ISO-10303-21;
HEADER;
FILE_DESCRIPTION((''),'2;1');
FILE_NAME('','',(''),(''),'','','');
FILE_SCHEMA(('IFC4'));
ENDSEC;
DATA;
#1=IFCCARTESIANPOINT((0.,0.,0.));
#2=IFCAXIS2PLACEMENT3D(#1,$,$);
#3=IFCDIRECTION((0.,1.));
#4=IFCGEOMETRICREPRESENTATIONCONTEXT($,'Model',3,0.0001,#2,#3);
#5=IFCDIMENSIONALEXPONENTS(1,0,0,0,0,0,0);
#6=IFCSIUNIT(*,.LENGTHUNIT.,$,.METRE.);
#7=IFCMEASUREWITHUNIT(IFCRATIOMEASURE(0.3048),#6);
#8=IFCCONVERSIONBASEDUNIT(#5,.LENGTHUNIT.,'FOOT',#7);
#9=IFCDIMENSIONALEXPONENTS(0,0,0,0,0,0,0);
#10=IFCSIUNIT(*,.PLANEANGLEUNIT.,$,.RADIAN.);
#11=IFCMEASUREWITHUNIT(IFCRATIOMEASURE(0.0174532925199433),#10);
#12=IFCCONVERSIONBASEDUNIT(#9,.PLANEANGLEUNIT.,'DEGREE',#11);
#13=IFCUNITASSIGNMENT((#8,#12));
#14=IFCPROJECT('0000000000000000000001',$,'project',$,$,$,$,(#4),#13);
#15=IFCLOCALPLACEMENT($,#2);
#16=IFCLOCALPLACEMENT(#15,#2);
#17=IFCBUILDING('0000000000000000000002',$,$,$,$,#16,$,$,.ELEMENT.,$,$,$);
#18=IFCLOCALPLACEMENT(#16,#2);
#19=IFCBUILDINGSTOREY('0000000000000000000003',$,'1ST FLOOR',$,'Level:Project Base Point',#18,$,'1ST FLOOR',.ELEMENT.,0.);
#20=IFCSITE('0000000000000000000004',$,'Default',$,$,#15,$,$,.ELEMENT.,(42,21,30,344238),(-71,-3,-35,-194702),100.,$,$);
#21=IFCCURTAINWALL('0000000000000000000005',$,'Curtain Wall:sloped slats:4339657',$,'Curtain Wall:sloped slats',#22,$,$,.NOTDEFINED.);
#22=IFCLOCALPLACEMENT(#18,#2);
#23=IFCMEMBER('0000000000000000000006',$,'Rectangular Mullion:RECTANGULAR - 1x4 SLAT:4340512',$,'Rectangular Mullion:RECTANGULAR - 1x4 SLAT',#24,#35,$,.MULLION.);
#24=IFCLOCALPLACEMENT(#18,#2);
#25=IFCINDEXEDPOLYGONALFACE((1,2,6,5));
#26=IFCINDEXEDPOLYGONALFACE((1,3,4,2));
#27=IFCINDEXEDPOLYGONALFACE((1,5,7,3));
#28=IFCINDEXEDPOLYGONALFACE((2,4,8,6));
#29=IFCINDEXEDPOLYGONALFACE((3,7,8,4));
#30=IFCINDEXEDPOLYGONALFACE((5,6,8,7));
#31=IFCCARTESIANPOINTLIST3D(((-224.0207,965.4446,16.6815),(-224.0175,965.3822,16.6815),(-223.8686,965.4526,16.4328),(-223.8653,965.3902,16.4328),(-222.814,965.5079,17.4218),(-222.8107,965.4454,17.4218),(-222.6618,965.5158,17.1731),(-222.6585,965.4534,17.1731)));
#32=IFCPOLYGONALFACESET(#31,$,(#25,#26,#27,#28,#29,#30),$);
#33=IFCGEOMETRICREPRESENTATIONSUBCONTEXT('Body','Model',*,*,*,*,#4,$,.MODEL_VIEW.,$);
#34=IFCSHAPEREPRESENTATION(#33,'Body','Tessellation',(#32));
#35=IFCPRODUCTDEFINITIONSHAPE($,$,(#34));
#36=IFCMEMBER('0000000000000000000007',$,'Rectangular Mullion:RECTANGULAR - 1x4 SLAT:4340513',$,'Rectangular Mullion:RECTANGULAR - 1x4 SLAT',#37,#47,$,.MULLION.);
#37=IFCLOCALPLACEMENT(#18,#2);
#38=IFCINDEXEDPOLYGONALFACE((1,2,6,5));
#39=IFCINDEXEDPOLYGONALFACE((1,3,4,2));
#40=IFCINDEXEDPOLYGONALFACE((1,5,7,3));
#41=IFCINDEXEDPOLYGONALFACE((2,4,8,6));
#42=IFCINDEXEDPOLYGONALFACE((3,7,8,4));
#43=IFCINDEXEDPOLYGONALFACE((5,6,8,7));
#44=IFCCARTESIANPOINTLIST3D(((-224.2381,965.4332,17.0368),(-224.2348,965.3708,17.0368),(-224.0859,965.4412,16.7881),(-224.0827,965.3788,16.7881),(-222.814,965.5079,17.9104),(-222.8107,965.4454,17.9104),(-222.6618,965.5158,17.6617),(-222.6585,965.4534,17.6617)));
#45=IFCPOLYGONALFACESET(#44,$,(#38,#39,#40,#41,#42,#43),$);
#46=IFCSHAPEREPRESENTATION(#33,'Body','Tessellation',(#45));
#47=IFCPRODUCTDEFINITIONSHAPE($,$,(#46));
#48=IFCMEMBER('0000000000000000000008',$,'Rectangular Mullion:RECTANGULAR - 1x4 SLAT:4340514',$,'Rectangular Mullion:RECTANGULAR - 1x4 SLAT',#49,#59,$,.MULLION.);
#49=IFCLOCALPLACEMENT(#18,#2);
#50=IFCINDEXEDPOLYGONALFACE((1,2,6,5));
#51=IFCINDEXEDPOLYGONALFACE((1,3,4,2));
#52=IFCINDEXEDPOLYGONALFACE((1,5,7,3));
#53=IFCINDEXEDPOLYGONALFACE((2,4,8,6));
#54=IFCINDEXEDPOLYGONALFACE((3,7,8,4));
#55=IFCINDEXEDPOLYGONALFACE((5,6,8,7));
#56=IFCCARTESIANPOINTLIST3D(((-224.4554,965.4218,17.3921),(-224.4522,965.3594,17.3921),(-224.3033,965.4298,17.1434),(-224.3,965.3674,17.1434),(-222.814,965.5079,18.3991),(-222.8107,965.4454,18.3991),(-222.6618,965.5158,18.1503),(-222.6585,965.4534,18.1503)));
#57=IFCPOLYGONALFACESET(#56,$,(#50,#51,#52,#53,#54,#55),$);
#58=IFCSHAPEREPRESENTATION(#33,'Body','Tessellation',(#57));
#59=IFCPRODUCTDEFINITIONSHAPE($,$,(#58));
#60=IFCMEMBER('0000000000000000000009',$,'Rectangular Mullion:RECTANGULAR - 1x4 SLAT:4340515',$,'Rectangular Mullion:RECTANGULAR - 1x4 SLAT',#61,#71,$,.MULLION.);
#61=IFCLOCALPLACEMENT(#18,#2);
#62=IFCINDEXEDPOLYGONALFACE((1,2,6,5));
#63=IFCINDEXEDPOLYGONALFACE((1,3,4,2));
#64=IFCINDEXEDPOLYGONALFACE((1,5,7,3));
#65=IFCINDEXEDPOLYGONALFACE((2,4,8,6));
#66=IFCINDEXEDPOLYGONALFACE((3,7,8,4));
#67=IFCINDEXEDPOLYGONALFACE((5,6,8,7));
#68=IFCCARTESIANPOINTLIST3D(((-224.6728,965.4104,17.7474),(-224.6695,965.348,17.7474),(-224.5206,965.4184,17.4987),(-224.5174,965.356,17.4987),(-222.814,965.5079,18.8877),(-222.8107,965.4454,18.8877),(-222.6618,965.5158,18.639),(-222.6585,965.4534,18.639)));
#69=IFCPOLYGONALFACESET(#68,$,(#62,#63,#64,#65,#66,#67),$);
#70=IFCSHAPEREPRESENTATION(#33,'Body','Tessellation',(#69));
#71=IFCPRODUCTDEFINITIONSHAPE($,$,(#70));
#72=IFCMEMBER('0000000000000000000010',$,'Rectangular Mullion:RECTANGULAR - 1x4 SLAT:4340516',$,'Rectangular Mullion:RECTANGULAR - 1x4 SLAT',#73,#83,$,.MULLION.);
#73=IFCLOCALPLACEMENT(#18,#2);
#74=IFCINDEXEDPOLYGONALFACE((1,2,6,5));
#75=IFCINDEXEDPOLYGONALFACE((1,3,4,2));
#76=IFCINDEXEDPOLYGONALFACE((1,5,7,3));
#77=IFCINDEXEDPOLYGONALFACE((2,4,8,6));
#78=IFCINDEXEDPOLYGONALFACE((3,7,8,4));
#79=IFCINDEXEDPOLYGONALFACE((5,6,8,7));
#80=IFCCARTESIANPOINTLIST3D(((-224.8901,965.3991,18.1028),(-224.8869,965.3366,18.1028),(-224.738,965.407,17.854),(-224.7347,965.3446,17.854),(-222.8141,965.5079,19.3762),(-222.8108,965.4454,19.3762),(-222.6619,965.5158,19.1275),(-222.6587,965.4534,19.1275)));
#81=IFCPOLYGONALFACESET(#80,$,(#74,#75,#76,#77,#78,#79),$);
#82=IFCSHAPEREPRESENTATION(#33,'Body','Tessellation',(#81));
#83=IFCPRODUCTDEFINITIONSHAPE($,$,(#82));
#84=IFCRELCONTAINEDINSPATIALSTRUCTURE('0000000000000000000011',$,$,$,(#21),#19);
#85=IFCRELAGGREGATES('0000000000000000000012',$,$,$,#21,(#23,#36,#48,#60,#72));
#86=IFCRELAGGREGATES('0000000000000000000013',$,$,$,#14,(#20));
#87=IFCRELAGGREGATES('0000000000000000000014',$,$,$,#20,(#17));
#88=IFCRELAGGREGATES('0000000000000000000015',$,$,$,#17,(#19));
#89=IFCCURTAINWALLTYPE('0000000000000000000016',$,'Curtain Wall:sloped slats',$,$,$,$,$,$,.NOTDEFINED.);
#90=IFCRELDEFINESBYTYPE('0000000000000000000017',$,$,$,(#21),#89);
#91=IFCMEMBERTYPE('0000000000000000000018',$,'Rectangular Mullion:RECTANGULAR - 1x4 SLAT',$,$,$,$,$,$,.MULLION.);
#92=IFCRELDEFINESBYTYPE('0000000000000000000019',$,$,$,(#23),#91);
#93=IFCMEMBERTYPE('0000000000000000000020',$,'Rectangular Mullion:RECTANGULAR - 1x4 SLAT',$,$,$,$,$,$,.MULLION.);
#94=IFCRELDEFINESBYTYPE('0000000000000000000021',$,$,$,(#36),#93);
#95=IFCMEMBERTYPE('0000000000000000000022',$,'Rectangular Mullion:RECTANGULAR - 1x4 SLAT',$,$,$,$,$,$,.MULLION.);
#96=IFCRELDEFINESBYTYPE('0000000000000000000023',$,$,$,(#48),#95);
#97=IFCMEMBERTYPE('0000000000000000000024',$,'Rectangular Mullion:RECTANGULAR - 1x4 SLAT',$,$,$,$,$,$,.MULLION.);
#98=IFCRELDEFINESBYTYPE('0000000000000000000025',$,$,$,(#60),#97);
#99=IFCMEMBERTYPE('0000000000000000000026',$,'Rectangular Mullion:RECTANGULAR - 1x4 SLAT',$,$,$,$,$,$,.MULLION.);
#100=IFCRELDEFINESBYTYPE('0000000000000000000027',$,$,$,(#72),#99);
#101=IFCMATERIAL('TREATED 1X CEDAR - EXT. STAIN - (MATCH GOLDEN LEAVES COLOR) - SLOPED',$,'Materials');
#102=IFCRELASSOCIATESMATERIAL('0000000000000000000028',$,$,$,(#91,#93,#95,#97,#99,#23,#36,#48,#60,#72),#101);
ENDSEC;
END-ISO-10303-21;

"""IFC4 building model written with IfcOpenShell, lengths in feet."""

from ifc_helpers import new_model, entity, si_unit, converted_unit, direction, frame, frame_2d, origin, place, context, subcontext, project, spatial, rectangle, extrude, source, transform, mapped, material, material_profile, profile_set, profile_usage, type_object, type_shapes, element, aggregate, save


model = new_model("IFC4")

# Units and contexts
model_context = context("Model", 3, precision=0.0001, world=origin(), true_north=direction((0.0, 1.0)))
body_context = subcontext(model_context, "Body", "Model", "MODEL_VIEW")
ifc_project = project(units=[converted_unit("LENGTHUNIT", "FOOT", entity("IfcRatioMeasure", 0.3048), si_unit("LENGTHUNIT", "METRE"), dimensions=[1, 0, 0, 0, 0, 0, 0]), converted_unit("PLANEANGLEUNIT", "DEGREE", entity("IfcRatioMeasure", 0.0174532925199433), si_unit("PLANEANGLEUNIT", "RADIAN"), dimensions=[0, 0, 0, 0, 0, 0, 0])], contexts=[model_context])

# Site, building, storey
site_placement = place(None, origin())
site = spatial("IfcSite", under=ifc_project, at=site_placement, Name="Default", CompositionType="ELEMENT", RefLatitude=(42, 21, 30, 344238), RefLongitude=(-71, -3, -35, -194702), RefElevation=100.0)
building_placement = place(site_placement, origin())
building = spatial("IfcBuilding", under=site, at=building_placement, CompositionType="ELEMENT")
storey_placement = place(building_placement, origin())
storey = spatial("IfcBuildingStorey", under=building, at=storey_placement, Name="1ST FLOOR", ObjectType="Level:Project Base Point", LongName="1ST FLOOR", CompositionType="ELEMENT", Elevation=0.0)

# Shared definitions
curtain_wall_type_1 = type_object("IfcCurtainWallType", Name="Curtain Wall:sloped slats", PredefinedType="NOTDEFINED")
ifc_material_1 = material(Name="TREATED 1X CEDAR - EXT. STAIN - (MATCH GOLDEN LEAVES COLOR) - SLOPED", Category="Materials")
ifc_material_profile_1 = material_profile(ifc_material_1, rectangle(XDim=0.0625, YDim=0.2917, at=frame_2d((0.0, 0.0), x_axis=(1.0, 0.0))), Name="RECTANGULAR - 1x4 SLAT")
ifc_profile_set_1 = profile_set([ifc_material_profile_1], Name="RECTANGULAR - 1x4 SLAT")

# Curtain wall, members
curtain_wall_1_placement = place(storey_placement, origin())
curtain_wall_1 = element("IfcCurtainWall", 1, at=curtain_wall_1_placement, inside=storey, type_object=curtain_wall_type_1, Name="Curtain Wall:sloped slats:4339657", ObjectType="Curtain Wall:sloped slats", PredefinedType="NOTDEFINED")
ifc_profile_usage_1 = profile_usage(ifc_profile_set_1)
member_type_1 = type_object("IfcMemberType", Name="Rectangular Mullion:RECTANGULAR - 1x4 SLAT", PredefinedType="MULLION", material=ifc_profile_set_1)
shared_shape_1 = source(origin(), body_context, "Body", "SweptSolid", [
    extrude(rectangle(XDim=0.0625, YDim=0.2917, at=frame_2d((0.0, 0.0), x_axis=(1.0, 0.0))), frame((0.0, 0.0, -1.4171), z_axis=(0.0, 0.0, 1.0), x_axis=(0.0, -1.0, 0.0)), (0.0, 0.0, 1.0), 1.4171),
])
type_shapes(member_type_1, [shared_shape_1])
member_1_placement = place(storey_placement, frame((-223.943, 965.4174, 16.5572), z_axis=(-0.851559, -0.044628, -0.522356), x_axis=(-0.52164, -0.027338, 0.852727)))
member_1 = element("IfcMember", 2, at=member_1_placement, type_object=member_type_1, material=ifc_profile_usage_1, Name="Rectangular Mullion:RECTANGULAR - 1x4 SLAT:4340512", ObjectType="Rectangular Mullion:RECTANGULAR - 1x4 SLAT", PredefinedType="MULLION", context=body_context, shape_type="MappedRepresentation", body=[
    mapped(shared_shape_1, transform((0.0, 0.0, 0.0), scale=1.0)),
])
ifc_profile_usage_2 = profile_usage(ifc_profile_set_1)
member_type_2 = type_object("IfcMemberType", Name="Rectangular Mullion:RECTANGULAR - 1x4 SLAT", PredefinedType="MULLION", material=ifc_profile_set_1)
shared_shape_2 = source(origin(), body_context, "Body", "SweptSolid", [
    extrude(rectangle(XDim=0.0625, YDim=0.2917, at=frame_2d((0.0, 0.0), x_axis=(1.0, 0.0))), frame((0.0, 0.0, -1.6724), z_axis=(0.0, 0.0, 1.0), x_axis=(0.0, -1.0, 0.0)), (0.0, 0.0, 1.0), 1.6724),
])
type_shapes(member_type_2, [shared_shape_2])
member_2_placement = place(storey_placement, frame((-224.1604, 965.406, 16.9125), z_axis=(-0.851559, -0.044628, -0.522356), x_axis=(-0.52164, -0.027338, 0.852727)))
member_2 = element("IfcMember", 3, at=member_2_placement, type_object=member_type_2, material=ifc_profile_usage_2, Name="Rectangular Mullion:RECTANGULAR - 1x4 SLAT:4340513", ObjectType="Rectangular Mullion:RECTANGULAR - 1x4 SLAT", PredefinedType="MULLION", context=body_context, shape_type="MappedRepresentation", body=[
    mapped(shared_shape_2, transform((0.0, 0.0, 0.0), scale=1.0)),
])
ifc_profile_usage_3 = profile_usage(ifc_profile_set_1)
member_type_3 = type_object("IfcMemberType", Name="Rectangular Mullion:RECTANGULAR - 1x4 SLAT", PredefinedType="MULLION", material=ifc_profile_set_1)
shared_shape_3 = source(origin(), body_context, "Body", "SweptSolid", [
    extrude(rectangle(XDim=0.0625, YDim=0.2917, at=frame_2d((0.0, 0.0), x_axis=(1.0, 0.0))), frame((0.0, 0.0, -1.9276), z_axis=(0.0, 0.0, 1.0), x_axis=(0.0, -1.0, 0.0)), (0.0, 0.0, 1.0), 1.9276),
])
type_shapes(member_type_3, [shared_shape_3])
member_3_placement = place(storey_placement, frame((-224.3777, 965.3946, 17.2678), z_axis=(-0.851559, -0.044628, -0.522356), x_axis=(-0.52164, -0.027338, 0.852727)))
member_3 = element("IfcMember", 4, at=member_3_placement, type_object=member_type_3, material=ifc_profile_usage_3, Name="Rectangular Mullion:RECTANGULAR - 1x4 SLAT:4340514", ObjectType="Rectangular Mullion:RECTANGULAR - 1x4 SLAT", PredefinedType="MULLION", context=body_context, shape_type="MappedRepresentation", body=[
    mapped(shared_shape_3, transform((0.0, 0.0, 0.0), scale=1.0)),
])
ifc_profile_usage_4 = profile_usage(ifc_profile_set_1)
member_type_4 = type_object("IfcMemberType", Name="Rectangular Mullion:RECTANGULAR - 1x4 SLAT", PredefinedType="MULLION", material=ifc_profile_set_1)
shared_shape_4 = source(origin(), body_context, "Body", "SweptSolid", [
    extrude(rectangle(XDim=0.0625, YDim=0.2917, at=frame_2d((0.0, 0.0), x_axis=(1.0, 0.0))), frame((0.0, 0.0, -2.1829), z_axis=(0.0, 0.0, 1.0), x_axis=(0.0, -1.0, 0.0)), (0.0, 0.0, 1.0), 2.1829),
])
type_shapes(member_type_4, [shared_shape_4])
member_4_placement = place(storey_placement, frame((-224.5951, 965.3832, 17.6231), z_axis=(-0.851559, -0.044628, -0.522356), x_axis=(-0.52164, -0.027338, 0.852727)))
member_4 = element("IfcMember", 5, at=member_4_placement, type_object=member_type_4, material=ifc_profile_usage_4, Name="Rectangular Mullion:RECTANGULAR - 1x4 SLAT:4340515", ObjectType="Rectangular Mullion:RECTANGULAR - 1x4 SLAT", PredefinedType="MULLION", context=body_context, shape_type="MappedRepresentation", body=[
    mapped(shared_shape_4, transform((0.0, 0.0, 0.0), scale=1.0)),
])
ifc_profile_usage_5 = profile_usage(ifc_profile_set_1)
member_type_5 = type_object("IfcMemberType", Name="Rectangular Mullion:RECTANGULAR - 1x4 SLAT", PredefinedType="MULLION", material=ifc_profile_set_1)
shared_shape_5 = source(origin(), body_context, "Body", "SweptSolid", [
    extrude(rectangle(XDim=0.0625, YDim=0.2917, at=frame_2d((0.0, 0.0), x_axis=(1.0, 0.0))), frame((0.0, 0.0, -2.4379), z_axis=(0.0, 0.0, 1.0), x_axis=(0.0, -1.0, 0.0)), (0.0, 0.0, 1.0), 2.4379),
])
type_shapes(member_type_5, [shared_shape_5])
member_5_placement = place(storey_placement, frame((-224.8124, 965.3718, 17.9784), z_axis=(-0.851559, -0.044628, -0.522356), x_axis=(-0.52164, -0.027338, 0.852727)))
member_5 = element("IfcMember", 6, at=member_5_placement, type_object=member_type_5, material=ifc_profile_usage_5, Name="Rectangular Mullion:RECTANGULAR - 1x4 SLAT:4340516", ObjectType="Rectangular Mullion:RECTANGULAR - 1x4 SLAT", PredefinedType="MULLION", context=body_context, shape_type="MappedRepresentation", body=[
    mapped(shared_shape_5, transform((0.0, 0.0, 0.0), scale=1.0)),
])
aggregate(curtain_wall_1, [member_1, member_2, member_3, member_4, member_5])

save(model, "model.ifc")
